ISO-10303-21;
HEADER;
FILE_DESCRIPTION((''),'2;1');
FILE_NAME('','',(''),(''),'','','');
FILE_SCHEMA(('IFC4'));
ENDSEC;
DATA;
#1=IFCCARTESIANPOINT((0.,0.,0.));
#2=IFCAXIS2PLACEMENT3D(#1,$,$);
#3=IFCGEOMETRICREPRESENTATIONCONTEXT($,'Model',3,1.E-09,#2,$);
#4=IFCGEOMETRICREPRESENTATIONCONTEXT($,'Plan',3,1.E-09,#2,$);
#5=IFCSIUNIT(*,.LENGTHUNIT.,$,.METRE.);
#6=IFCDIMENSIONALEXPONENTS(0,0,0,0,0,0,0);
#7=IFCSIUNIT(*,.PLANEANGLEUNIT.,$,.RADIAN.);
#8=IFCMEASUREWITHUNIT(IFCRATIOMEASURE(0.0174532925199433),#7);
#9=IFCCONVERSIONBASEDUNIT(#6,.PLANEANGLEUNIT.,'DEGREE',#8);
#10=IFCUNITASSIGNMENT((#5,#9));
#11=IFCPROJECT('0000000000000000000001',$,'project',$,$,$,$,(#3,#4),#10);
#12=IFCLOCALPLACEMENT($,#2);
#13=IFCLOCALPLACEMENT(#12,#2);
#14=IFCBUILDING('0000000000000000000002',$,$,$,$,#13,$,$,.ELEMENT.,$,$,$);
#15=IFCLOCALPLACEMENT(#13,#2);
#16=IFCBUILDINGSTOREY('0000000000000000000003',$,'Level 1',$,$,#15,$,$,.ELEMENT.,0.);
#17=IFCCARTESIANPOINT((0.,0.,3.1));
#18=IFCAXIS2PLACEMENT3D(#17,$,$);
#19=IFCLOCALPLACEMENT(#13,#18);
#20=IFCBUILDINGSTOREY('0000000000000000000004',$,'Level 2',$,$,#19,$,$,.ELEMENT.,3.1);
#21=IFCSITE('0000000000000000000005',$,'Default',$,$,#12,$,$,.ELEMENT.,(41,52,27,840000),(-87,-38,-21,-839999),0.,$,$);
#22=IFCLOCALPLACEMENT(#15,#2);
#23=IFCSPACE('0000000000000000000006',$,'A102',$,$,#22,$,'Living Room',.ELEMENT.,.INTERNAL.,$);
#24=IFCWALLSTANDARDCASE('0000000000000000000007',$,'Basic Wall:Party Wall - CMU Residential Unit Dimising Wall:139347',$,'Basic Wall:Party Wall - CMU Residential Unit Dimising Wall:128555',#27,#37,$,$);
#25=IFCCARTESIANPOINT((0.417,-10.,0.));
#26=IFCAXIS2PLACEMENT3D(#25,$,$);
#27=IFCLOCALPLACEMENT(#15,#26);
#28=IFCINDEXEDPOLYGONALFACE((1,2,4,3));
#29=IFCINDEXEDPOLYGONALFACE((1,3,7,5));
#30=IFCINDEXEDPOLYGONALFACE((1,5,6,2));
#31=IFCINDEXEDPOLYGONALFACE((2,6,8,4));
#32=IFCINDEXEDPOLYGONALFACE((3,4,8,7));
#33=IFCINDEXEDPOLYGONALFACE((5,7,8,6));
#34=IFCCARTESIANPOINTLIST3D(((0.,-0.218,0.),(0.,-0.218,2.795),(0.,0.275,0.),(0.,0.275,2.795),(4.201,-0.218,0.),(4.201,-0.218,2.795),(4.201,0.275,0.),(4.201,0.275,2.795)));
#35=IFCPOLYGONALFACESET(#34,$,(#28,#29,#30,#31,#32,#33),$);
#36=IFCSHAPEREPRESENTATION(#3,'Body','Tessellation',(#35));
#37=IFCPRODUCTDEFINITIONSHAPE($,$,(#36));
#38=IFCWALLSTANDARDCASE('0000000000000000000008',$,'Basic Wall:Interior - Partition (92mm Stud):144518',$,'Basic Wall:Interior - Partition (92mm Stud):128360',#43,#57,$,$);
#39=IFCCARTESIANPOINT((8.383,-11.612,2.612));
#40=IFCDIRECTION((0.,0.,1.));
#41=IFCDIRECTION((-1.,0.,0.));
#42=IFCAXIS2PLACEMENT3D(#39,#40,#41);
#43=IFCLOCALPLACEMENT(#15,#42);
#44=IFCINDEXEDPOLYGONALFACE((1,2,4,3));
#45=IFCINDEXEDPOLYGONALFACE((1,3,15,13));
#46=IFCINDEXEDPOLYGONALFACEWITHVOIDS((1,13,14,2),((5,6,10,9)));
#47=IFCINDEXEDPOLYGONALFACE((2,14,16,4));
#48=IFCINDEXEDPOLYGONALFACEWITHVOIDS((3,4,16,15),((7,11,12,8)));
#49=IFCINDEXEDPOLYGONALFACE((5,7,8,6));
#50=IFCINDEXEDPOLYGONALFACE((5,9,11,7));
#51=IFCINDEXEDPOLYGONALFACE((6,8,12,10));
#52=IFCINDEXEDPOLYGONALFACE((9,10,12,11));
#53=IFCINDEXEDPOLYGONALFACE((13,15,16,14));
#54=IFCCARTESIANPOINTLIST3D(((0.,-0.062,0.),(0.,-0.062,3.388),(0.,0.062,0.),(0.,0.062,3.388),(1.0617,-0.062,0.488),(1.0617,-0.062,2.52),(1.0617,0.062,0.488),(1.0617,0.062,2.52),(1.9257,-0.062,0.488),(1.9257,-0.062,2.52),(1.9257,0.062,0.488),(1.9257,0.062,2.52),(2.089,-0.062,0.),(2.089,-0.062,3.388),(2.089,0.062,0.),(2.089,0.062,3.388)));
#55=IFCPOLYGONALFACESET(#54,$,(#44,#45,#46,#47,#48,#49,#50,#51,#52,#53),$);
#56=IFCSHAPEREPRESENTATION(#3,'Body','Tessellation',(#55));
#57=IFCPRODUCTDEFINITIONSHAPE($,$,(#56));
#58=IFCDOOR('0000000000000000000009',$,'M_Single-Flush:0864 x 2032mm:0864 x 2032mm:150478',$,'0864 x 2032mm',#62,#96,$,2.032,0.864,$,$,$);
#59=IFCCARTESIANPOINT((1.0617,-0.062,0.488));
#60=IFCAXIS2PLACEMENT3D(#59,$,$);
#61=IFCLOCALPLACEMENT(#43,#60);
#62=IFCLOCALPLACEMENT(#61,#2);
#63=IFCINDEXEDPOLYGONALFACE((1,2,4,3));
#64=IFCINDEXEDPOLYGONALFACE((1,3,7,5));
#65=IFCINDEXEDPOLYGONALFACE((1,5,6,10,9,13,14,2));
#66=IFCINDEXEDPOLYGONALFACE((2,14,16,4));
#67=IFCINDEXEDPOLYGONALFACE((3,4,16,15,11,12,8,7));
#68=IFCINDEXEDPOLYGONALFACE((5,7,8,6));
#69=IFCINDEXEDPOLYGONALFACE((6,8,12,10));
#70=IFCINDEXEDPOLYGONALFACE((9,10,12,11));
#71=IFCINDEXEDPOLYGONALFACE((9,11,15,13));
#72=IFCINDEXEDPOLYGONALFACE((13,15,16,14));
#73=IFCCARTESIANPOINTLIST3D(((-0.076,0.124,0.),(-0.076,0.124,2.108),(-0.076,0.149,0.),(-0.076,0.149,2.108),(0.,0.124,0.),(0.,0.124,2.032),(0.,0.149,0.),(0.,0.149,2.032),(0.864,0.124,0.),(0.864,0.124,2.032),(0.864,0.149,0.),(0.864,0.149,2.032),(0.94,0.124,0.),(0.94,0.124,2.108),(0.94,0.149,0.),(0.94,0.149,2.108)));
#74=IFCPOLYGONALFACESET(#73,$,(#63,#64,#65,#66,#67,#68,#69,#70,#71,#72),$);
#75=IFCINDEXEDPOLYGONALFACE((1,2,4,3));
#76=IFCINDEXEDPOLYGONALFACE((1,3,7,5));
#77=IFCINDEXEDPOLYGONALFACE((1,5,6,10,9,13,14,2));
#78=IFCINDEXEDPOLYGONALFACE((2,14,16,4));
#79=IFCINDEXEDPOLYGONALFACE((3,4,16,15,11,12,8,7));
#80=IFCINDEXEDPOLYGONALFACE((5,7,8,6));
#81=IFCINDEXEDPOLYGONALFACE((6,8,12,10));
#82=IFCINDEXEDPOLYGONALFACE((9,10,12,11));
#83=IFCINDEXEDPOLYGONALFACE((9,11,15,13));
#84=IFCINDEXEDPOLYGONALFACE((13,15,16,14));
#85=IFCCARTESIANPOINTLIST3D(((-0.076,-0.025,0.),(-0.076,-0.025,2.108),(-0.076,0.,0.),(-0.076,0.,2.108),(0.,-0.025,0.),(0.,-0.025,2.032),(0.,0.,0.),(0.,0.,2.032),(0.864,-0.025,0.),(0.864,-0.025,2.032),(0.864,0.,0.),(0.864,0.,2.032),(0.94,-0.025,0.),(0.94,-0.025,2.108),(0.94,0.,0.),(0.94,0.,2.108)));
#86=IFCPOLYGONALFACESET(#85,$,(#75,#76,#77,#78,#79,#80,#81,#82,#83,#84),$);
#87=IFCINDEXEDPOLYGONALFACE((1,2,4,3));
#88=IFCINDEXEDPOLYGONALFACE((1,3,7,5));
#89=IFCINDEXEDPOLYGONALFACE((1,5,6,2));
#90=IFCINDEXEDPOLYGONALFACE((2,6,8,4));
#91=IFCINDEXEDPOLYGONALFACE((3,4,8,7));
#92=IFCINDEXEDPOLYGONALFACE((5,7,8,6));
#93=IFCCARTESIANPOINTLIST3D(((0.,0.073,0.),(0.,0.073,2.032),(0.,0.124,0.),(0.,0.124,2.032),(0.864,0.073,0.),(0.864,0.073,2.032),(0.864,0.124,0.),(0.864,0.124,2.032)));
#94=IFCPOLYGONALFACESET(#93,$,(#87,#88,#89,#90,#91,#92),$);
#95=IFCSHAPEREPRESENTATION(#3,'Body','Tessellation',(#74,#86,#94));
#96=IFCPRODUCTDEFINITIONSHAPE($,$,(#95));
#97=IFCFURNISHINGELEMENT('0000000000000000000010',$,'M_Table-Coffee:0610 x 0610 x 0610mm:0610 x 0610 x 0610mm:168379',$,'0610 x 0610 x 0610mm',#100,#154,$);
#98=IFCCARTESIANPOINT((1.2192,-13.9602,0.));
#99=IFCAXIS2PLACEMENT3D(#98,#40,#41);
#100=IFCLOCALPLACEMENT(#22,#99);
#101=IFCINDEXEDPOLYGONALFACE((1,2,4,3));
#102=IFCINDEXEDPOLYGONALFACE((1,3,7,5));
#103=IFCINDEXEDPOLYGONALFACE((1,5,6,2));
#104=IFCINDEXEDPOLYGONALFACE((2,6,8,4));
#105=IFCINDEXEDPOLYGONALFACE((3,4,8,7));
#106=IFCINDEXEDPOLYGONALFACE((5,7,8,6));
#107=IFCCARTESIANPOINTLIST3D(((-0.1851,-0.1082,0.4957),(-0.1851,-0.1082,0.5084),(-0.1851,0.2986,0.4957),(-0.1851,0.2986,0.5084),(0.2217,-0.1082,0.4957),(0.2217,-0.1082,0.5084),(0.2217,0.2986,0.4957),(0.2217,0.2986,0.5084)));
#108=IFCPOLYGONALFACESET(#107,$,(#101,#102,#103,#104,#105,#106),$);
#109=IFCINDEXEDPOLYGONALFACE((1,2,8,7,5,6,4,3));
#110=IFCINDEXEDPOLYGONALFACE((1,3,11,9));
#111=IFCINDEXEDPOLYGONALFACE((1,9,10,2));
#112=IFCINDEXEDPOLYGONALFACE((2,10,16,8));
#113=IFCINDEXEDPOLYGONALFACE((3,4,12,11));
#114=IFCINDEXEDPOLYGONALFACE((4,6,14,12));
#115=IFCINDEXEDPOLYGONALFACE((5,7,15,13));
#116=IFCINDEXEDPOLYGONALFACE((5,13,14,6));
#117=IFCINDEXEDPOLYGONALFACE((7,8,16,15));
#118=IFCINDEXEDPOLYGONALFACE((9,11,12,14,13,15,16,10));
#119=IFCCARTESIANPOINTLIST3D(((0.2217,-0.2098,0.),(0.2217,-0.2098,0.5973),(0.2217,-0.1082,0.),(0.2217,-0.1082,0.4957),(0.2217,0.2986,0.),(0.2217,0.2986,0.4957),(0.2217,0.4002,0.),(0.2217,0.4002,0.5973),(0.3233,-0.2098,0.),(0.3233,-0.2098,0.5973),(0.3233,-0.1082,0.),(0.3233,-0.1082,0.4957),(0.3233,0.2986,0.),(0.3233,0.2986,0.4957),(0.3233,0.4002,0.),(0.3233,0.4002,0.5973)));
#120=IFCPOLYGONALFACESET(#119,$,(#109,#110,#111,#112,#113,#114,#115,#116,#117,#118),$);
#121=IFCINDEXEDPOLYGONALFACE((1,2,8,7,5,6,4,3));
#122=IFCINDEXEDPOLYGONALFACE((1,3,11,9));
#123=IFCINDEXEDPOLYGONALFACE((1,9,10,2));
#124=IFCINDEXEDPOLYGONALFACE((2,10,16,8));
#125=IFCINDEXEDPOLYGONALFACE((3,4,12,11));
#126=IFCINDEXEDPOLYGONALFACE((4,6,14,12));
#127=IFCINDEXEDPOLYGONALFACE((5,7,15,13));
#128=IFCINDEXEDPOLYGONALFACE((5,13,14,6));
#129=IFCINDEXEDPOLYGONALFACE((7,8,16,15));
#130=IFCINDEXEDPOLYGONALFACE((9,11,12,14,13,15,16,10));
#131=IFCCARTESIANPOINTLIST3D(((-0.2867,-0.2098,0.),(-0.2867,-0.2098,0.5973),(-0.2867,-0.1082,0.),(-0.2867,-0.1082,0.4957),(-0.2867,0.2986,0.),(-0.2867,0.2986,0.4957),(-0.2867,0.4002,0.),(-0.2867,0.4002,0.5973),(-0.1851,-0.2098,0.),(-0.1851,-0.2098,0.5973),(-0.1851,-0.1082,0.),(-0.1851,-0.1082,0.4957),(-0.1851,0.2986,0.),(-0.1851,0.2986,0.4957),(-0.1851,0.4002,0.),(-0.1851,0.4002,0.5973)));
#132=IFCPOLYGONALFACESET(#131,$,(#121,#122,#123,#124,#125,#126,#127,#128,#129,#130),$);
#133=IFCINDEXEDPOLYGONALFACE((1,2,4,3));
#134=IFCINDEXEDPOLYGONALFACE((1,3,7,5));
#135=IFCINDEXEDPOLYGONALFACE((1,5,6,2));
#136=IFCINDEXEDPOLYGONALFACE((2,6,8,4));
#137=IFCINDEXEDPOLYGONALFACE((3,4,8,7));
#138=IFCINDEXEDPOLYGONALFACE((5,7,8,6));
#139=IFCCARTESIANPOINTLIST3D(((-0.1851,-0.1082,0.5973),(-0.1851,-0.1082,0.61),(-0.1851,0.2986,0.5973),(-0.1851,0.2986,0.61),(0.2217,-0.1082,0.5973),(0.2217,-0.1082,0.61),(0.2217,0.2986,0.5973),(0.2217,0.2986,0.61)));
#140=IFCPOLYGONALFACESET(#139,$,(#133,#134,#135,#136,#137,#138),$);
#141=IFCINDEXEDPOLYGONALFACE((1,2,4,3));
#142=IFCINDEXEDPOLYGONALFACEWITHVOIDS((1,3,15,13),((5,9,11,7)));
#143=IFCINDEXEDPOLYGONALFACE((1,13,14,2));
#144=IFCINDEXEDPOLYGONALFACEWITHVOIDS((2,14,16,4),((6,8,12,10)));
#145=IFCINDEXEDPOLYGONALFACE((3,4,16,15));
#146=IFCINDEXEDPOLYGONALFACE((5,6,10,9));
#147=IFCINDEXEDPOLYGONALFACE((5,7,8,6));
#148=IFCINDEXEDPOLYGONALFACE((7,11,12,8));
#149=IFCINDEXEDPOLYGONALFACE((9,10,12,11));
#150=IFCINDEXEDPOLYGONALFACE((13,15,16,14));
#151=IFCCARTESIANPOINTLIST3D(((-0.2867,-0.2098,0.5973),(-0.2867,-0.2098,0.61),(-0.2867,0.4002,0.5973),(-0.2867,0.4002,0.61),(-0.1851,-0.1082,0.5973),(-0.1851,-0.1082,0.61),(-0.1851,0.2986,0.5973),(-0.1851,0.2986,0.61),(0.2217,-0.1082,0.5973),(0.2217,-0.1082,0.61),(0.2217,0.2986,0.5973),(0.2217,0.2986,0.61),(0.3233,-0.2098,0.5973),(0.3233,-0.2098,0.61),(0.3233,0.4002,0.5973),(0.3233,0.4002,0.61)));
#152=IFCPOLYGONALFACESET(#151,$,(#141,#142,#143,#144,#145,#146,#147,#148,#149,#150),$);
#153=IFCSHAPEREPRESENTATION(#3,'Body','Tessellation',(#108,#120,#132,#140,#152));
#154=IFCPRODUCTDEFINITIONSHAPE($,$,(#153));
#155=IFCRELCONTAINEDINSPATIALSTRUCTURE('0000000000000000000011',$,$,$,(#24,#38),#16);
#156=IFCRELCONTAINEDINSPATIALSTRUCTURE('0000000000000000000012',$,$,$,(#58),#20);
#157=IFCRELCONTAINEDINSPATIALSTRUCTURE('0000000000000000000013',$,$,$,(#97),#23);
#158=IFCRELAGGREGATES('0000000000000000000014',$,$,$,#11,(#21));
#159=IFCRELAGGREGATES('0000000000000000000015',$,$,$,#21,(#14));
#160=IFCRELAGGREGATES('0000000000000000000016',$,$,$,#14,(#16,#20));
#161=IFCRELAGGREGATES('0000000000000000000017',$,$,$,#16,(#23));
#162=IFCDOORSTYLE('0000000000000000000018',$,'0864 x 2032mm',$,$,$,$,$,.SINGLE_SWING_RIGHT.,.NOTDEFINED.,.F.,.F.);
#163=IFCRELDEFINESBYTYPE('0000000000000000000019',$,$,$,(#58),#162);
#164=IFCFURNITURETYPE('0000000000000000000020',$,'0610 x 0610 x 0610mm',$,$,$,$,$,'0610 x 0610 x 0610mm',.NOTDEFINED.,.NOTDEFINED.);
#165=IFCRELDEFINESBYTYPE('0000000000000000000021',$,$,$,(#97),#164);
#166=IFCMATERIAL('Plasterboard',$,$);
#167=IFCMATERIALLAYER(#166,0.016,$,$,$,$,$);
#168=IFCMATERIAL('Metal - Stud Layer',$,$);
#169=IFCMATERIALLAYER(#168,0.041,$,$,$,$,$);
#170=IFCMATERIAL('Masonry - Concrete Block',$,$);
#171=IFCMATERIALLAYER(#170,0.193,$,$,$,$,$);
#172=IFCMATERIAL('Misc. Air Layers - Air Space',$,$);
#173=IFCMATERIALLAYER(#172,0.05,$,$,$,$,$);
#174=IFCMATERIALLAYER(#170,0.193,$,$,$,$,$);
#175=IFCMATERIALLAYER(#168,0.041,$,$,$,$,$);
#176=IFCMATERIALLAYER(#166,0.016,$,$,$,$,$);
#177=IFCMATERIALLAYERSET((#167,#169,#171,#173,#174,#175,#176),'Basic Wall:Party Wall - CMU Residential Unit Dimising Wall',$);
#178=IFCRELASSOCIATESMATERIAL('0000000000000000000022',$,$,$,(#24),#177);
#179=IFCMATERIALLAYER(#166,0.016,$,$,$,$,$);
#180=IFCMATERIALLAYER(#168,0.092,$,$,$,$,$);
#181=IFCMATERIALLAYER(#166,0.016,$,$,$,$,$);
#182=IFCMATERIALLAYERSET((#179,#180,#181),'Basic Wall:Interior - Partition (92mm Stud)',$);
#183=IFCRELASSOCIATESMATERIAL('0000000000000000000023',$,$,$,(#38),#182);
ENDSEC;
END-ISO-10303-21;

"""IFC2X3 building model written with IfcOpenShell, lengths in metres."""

from ifc_helpers import new_model, entity, si_unit, converted_unit, frame, frame_2d, origin, origin_2d_with_axis, place, context, project, spatial, polyline, rectangle, outline, extrude, clip, bounded_halfspace, source, transform, mapped, material, layer, layer_set, layer_usage, type_object, type_shapes, element, fill, save


model = new_model("IFC2X3")

# Units and contexts
model_context = context("Model", 3, precision=1e-09, world=origin())
plan_context = context("Plan", 3, precision=1e-09, world=origin())
ifc_project = project(units=[si_unit("LENGTHUNIT", "METRE"), converted_unit("PLANEANGLEUNIT", "DEGREE", entity("IfcRatioMeasure", 0.0174532925199433), si_unit("PLANEANGLEUNIT", "RADIAN"), dimensions=[0, 0, 0, 0, 0, 0, 0])], contexts=[model_context, plan_context])

# Site, building, storey
site_placement = place(None, origin())
site = spatial("IfcSite", under=ifc_project, at=site_placement, Name="Default", CompositionType="ELEMENT", RefLatitude=(41, 52, 27, 840000), RefLongitude=(-87, -38, -21, -839999), RefElevation=0.0)
building_placement = place(site_placement, origin())
building = spatial("IfcBuilding", under=site, at=building_placement, CompositionType="ELEMENT")
storey_1_placement = place(building_placement, origin())
storey_1 = spatial("IfcBuildingStorey", under=building, at=storey_1_placement, Name="Level 1", CompositionType="ELEMENT", Elevation=0.0)

# Shared definitions
ifc_material_1 = material(Name="Misc. Air Layers - Air Space")
ifc_material_2 = material(Name="Masonry - Concrete Block")
ifc_material_3 = material(Name="Metal - Stud Layer")
ifc_material_4 = material(Name="Plasterboard")

# Wall
ifc_layer_1 = layer(ifc_material_4, 0.016)
ifc_layer_2 = layer(ifc_material_3, 0.041)
ifc_layer_3 = layer(ifc_material_2, 0.193)
ifc_layer_4 = layer(ifc_material_1, 0.05)
ifc_layer_5 = layer(ifc_material_2, 0.193)
ifc_layer_6 = layer(ifc_material_3, 0.041)
ifc_layer_7 = layer(ifc_material_4, 0.016)
ifc_layer_set_1 = layer_set([ifc_layer_1, ifc_layer_2, ifc_layer_3, ifc_layer_4, ifc_layer_5, ifc_layer_6, ifc_layer_7], Name="Basic Wall:Party Wall - CMU Residential Unit Dimising Wall")
ifc_layer_usage_1 = layer_usage(ifc_layer_set_1, "AXIS2", "NEGATIVE", 0.275)
wall_1_placement = place(storey_1_placement, frame((0.417, -10.0, 0.0)))
element("IfcWallStandardCase", 1, at=wall_1_placement, inside=storey_1, material=ifc_layer_usage_1, Name="Basic Wall:Party Wall - CMU Residential Unit Dimising Wall:139347", ObjectType="Basic Wall:Party Wall - CMU Residential Unit Dimising Wall:128555", context=model_context, shape_type="Clipping", body=[
    clip(clip(extrude(rectangle(XDim=4.201, YDim=0.55, at=frame_2d((2.1005, 0.0), x_axis=(-1.0, 0.0))), origin(), (0.0, 0.0, 1.0), 2.795), bounded_halfspace(frame((0.0, -0.218, 0.0), z_axis=(0.0, 1.0, 0.0), x_axis=(-1.0, 0.0, 0.0)), True, frame((0.0, -0.218, 0.0), z_axis=(0.0, 1.0, 0.0), x_axis=(-1.0, 0.0, 0.0)), polyline([(0.0, 0.0), (0.0, 2.795), (-4.201, 2.795), (-4.201, 0.0), (0.0, 0.0)]))), bounded_halfspace(frame((4.201, 0.275, 0.0), z_axis=(-1.0, 0.0, 0.0), x_axis=(0.0, -1.0, 0.0)), True, frame((4.201, 0.275, 0.0), z_axis=(-1.0, 0.0, 0.0), x_axis=(0.0, -1.0, 0.0)), polyline([(0.0, 0.0), (0.493, 0.0), (0.493, 2.795), (0.0, 2.795), (0.0, 0.0)]))),
])
ifc_layer_8 = layer(ifc_material_4, 0.016)
ifc_layer_9 = layer(ifc_material_3, 0.092)
ifc_layer_10 = layer(ifc_material_4, 0.016)
ifc_layer_set_2 = layer_set([ifc_layer_8, ifc_layer_9, ifc_layer_10], Name="Basic Wall:Interior - Partition (92mm Stud)")
ifc_layer_usage_2 = layer_usage(ifc_layer_set_2, "AXIS2", "NEGATIVE", 0.062)

# Wall, opening
wall_2_placement = place(storey_1_placement, frame((8.383, -11.612, 2.612), z_axis=(0.0, 0.0, 1.0), x_axis=(-1.0, 0.0, 0.0)))
wall_2 = element("IfcWallStandardCase", 2, at=wall_2_placement, inside=storey_1, material=ifc_layer_usage_2, Name="Basic Wall:Interior - Partition (92mm Stud):144518", ObjectType="Basic Wall:Interior - Partition (92mm Stud):128360", context=model_context, shape_type="SweptSolid", body=[
    extrude(rectangle(XDim=2.089, YDim=0.124, at=frame_2d((1.0445, 0.0), x_axis=(-1.0, 0.0))), origin(), (0.0, 0.0, 1.0), 3.388),
])
opening_1_placement = place(wall_2_placement, frame((1.0617, -0.062, 0.488)))
opening_1 = element("IfcOpeningElement", 3, at=opening_1_placement, cuts=wall_2, ObjectType="Opening", context=model_context, shape_type="SweptSolid", body=[
    extrude(rectangle(XDim=0.864, YDim=2.032, at=frame_2d((1.016, 0.432), x_axis=(0.0, 1.0))), frame((0.0, 0.0, 0.0), z_axis=(0.0, 1.0, 0.0), x_axis=(0.0, 0.0, 1.0)), (0.0, 0.0, 1.0), 0.124),
])

# Shared definitions
storey_2_placement = place(building_placement, frame((0.0, 0.0, 3.1)))
storey_2 = spatial("IfcBuildingStorey", under=building, at=storey_2_placement, Name="Level 2", CompositionType="ELEMENT", Elevation=3.1)

# Door
door_style_1 = type_object("IfcDoorStyle", Name="0864 x 2032mm", ConstructionType="NOTDEFINED", OperationType="SINGLE_SWING_RIGHT", ParameterTakesPrecedence=False, Sizeable=False)
shared_shape_1 = source(origin(), model_context, "Body", "SweptSolid", [
    extrude(outline(polyline([(-0.508, -1.073), (0.508, -1.073), (0.508, 1.035), (0.432, 1.035), (0.432, -0.997), (-0.432, -0.997), (-0.432, 1.035), (-0.508, 1.035), (-0.508, -1.073)])), frame((0.432, 0.124, 1.035), z_axis=(0.0, 1.0, 0.0), x_axis=(1.0, 0.0, 0.0)), (0.0, 0.0, 1.0), 0.025),
    extrude(outline(polyline([(-1.073, -0.508), (1.035, -0.508), (1.035, -0.432), (-0.997, -0.432), (-0.997, 0.432), (1.035, 0.432), (1.035, 0.508), (-1.073, 0.508), (-1.073, -0.508)])), frame((0.432, -0.025, 1.035), z_axis=(0.0, 1.0, 0.0), x_axis=(0.0, 0.0, -1.0)), (0.0, 0.0, 1.0), 0.025),
    extrude(rectangle(XDim=0.051, YDim=0.864, at=origin_2d_with_axis()), frame((0.432, 0.0985, 0.0), z_axis=(0.0, 0.0, 1.0), x_axis=(0.0, 1.0, 0.0)), (0.0, 0.0, 1.0), 2.032),
])
type_shapes(door_style_1, [shared_shape_1])
door_1_placement = place(opening_1_placement, origin())
door_1 = element("IfcDoor", 4, at=door_1_placement, inside=storey_2, type_object=door_style_1, Name="M_Single-Flush:0864 x 2032mm:0864 x 2032mm:150478", ObjectType="0864 x 2032mm", OverallHeight=2.032, OverallWidth=0.864, context=model_context, shape_type="MappedRepresentation", body=[
    mapped(shared_shape_1, transform((0.0, 0.0, 0.0), scale=1.0)),
])
fill(opening_1, door_1)

# Shared definitions
space_1_placement = place(storey_1_placement, origin())
space_1 = spatial("IfcSpace", under=storey_1, at=space_1_placement, Name="A102", LongName="Living Room", CompositionType="ELEMENT", InteriorOrExteriorSpace="INTERNAL")

# Furnishing element
furniture_type_1 = type_object("IfcFurnitureType", Name="0610 x 0610 x 0610mm", ElementType="0610 x 0610 x 0610mm", AssemblyPlace="NOTDEFINED")
shared_shape_2 = source(origin(), model_context, "Body", "SweptSolid", [
    extrude(rectangle(XDim=0.4068, YDim=0.4068, at=origin_2d_with_axis()), frame((0.0183, 0.0952, 0.4957), z_axis=(0.0, 0.0, 1.0), x_axis=(-1.0, 0.0, 0.0)), (0.0, 0.0, 1.0), 0.0127),
    extrude(outline(polyline([(-0.2732, -0.305), (0.324, -0.305), (0.324, 0.305), (-0.2732, 0.305), (-0.2732, 0.2034), (0.2225, 0.2034), (0.2225, -0.2034), (-0.2732, -0.2034), (-0.2732, -0.305)])), frame((0.2217, 0.0952, 0.2732), z_axis=(1.0, 0.0, 0.0), x_axis=(0.0, 0.0, 1.0)), (0.0, 0.0, 1.0), 0.1016),
    extrude(outline(polyline([(-0.305, -0.3241), (0.305, -0.3241), (0.305, 0.2733), (0.2034, 0.2733), (0.2034, -0.2224), (-0.2034, -0.2224), (-0.2034, 0.2733), (-0.305, 0.2733), (-0.305, -0.3241)])), frame((-0.2867, 0.0952, 0.2733), z_axis=(1.0, 0.0, 0.0), x_axis=(0.0, -1.0, 0.0)), (0.0, 0.0, 1.0), 0.1016),
    extrude(rectangle(XDim=0.4068, YDim=0.4068, at=origin_2d_with_axis()), frame((0.0183, 0.0952, 0.5973), z_axis=(0.0, 0.0, 1.0), x_axis=(-1.0, 0.0, 0.0)), (0.0, 0.0, 1.0), 0.0127),
    extrude(outline(polyline([(-0.305, -0.305), (0.305, -0.305), (0.305, 0.305), (-0.305, 0.305), (-0.305, -0.305)]), holes=[polyline([(-0.2034, -0.2034), (-0.2034, 0.2034), (0.2034, 0.2034), (0.2034, -0.2034), (-0.2034, -0.2034)])]), frame((0.0183, 0.0952, 0.5973), z_axis=(0.0, 0.0, 1.0), x_axis=(-1.0, 0.0, 0.0)), (0.0, 0.0, 1.0), 0.0127),
])
type_shapes(furniture_type_1, [shared_shape_2])
for number, where, z_axis, x_axis, name in (
    (5, (1.2192, -13.9602, 0.0), (0.0, 0.0, 1.0), (-1.0, 0.0, 0.0), "M_Table-Coffee:0610 x 0610 x 0610mm:0610 x 0610 x 0610mm:168379"),
):
    element("IfcFurnishingElement", number, at=place(space_1_placement, frame(where, z_axis=z_axis, x_axis=x_axis)), inside=space_1, type_object=furniture_type_1, Name=name, ObjectType="0610 x 0610 x 0610mm", context=model_context, shape_type="MappedRepresentation", body=[
        mapped(shared_shape_2, transform((0.0, 0.0, 0.0), scale=1.0)),
    ])

save(model, "model.ifc")
